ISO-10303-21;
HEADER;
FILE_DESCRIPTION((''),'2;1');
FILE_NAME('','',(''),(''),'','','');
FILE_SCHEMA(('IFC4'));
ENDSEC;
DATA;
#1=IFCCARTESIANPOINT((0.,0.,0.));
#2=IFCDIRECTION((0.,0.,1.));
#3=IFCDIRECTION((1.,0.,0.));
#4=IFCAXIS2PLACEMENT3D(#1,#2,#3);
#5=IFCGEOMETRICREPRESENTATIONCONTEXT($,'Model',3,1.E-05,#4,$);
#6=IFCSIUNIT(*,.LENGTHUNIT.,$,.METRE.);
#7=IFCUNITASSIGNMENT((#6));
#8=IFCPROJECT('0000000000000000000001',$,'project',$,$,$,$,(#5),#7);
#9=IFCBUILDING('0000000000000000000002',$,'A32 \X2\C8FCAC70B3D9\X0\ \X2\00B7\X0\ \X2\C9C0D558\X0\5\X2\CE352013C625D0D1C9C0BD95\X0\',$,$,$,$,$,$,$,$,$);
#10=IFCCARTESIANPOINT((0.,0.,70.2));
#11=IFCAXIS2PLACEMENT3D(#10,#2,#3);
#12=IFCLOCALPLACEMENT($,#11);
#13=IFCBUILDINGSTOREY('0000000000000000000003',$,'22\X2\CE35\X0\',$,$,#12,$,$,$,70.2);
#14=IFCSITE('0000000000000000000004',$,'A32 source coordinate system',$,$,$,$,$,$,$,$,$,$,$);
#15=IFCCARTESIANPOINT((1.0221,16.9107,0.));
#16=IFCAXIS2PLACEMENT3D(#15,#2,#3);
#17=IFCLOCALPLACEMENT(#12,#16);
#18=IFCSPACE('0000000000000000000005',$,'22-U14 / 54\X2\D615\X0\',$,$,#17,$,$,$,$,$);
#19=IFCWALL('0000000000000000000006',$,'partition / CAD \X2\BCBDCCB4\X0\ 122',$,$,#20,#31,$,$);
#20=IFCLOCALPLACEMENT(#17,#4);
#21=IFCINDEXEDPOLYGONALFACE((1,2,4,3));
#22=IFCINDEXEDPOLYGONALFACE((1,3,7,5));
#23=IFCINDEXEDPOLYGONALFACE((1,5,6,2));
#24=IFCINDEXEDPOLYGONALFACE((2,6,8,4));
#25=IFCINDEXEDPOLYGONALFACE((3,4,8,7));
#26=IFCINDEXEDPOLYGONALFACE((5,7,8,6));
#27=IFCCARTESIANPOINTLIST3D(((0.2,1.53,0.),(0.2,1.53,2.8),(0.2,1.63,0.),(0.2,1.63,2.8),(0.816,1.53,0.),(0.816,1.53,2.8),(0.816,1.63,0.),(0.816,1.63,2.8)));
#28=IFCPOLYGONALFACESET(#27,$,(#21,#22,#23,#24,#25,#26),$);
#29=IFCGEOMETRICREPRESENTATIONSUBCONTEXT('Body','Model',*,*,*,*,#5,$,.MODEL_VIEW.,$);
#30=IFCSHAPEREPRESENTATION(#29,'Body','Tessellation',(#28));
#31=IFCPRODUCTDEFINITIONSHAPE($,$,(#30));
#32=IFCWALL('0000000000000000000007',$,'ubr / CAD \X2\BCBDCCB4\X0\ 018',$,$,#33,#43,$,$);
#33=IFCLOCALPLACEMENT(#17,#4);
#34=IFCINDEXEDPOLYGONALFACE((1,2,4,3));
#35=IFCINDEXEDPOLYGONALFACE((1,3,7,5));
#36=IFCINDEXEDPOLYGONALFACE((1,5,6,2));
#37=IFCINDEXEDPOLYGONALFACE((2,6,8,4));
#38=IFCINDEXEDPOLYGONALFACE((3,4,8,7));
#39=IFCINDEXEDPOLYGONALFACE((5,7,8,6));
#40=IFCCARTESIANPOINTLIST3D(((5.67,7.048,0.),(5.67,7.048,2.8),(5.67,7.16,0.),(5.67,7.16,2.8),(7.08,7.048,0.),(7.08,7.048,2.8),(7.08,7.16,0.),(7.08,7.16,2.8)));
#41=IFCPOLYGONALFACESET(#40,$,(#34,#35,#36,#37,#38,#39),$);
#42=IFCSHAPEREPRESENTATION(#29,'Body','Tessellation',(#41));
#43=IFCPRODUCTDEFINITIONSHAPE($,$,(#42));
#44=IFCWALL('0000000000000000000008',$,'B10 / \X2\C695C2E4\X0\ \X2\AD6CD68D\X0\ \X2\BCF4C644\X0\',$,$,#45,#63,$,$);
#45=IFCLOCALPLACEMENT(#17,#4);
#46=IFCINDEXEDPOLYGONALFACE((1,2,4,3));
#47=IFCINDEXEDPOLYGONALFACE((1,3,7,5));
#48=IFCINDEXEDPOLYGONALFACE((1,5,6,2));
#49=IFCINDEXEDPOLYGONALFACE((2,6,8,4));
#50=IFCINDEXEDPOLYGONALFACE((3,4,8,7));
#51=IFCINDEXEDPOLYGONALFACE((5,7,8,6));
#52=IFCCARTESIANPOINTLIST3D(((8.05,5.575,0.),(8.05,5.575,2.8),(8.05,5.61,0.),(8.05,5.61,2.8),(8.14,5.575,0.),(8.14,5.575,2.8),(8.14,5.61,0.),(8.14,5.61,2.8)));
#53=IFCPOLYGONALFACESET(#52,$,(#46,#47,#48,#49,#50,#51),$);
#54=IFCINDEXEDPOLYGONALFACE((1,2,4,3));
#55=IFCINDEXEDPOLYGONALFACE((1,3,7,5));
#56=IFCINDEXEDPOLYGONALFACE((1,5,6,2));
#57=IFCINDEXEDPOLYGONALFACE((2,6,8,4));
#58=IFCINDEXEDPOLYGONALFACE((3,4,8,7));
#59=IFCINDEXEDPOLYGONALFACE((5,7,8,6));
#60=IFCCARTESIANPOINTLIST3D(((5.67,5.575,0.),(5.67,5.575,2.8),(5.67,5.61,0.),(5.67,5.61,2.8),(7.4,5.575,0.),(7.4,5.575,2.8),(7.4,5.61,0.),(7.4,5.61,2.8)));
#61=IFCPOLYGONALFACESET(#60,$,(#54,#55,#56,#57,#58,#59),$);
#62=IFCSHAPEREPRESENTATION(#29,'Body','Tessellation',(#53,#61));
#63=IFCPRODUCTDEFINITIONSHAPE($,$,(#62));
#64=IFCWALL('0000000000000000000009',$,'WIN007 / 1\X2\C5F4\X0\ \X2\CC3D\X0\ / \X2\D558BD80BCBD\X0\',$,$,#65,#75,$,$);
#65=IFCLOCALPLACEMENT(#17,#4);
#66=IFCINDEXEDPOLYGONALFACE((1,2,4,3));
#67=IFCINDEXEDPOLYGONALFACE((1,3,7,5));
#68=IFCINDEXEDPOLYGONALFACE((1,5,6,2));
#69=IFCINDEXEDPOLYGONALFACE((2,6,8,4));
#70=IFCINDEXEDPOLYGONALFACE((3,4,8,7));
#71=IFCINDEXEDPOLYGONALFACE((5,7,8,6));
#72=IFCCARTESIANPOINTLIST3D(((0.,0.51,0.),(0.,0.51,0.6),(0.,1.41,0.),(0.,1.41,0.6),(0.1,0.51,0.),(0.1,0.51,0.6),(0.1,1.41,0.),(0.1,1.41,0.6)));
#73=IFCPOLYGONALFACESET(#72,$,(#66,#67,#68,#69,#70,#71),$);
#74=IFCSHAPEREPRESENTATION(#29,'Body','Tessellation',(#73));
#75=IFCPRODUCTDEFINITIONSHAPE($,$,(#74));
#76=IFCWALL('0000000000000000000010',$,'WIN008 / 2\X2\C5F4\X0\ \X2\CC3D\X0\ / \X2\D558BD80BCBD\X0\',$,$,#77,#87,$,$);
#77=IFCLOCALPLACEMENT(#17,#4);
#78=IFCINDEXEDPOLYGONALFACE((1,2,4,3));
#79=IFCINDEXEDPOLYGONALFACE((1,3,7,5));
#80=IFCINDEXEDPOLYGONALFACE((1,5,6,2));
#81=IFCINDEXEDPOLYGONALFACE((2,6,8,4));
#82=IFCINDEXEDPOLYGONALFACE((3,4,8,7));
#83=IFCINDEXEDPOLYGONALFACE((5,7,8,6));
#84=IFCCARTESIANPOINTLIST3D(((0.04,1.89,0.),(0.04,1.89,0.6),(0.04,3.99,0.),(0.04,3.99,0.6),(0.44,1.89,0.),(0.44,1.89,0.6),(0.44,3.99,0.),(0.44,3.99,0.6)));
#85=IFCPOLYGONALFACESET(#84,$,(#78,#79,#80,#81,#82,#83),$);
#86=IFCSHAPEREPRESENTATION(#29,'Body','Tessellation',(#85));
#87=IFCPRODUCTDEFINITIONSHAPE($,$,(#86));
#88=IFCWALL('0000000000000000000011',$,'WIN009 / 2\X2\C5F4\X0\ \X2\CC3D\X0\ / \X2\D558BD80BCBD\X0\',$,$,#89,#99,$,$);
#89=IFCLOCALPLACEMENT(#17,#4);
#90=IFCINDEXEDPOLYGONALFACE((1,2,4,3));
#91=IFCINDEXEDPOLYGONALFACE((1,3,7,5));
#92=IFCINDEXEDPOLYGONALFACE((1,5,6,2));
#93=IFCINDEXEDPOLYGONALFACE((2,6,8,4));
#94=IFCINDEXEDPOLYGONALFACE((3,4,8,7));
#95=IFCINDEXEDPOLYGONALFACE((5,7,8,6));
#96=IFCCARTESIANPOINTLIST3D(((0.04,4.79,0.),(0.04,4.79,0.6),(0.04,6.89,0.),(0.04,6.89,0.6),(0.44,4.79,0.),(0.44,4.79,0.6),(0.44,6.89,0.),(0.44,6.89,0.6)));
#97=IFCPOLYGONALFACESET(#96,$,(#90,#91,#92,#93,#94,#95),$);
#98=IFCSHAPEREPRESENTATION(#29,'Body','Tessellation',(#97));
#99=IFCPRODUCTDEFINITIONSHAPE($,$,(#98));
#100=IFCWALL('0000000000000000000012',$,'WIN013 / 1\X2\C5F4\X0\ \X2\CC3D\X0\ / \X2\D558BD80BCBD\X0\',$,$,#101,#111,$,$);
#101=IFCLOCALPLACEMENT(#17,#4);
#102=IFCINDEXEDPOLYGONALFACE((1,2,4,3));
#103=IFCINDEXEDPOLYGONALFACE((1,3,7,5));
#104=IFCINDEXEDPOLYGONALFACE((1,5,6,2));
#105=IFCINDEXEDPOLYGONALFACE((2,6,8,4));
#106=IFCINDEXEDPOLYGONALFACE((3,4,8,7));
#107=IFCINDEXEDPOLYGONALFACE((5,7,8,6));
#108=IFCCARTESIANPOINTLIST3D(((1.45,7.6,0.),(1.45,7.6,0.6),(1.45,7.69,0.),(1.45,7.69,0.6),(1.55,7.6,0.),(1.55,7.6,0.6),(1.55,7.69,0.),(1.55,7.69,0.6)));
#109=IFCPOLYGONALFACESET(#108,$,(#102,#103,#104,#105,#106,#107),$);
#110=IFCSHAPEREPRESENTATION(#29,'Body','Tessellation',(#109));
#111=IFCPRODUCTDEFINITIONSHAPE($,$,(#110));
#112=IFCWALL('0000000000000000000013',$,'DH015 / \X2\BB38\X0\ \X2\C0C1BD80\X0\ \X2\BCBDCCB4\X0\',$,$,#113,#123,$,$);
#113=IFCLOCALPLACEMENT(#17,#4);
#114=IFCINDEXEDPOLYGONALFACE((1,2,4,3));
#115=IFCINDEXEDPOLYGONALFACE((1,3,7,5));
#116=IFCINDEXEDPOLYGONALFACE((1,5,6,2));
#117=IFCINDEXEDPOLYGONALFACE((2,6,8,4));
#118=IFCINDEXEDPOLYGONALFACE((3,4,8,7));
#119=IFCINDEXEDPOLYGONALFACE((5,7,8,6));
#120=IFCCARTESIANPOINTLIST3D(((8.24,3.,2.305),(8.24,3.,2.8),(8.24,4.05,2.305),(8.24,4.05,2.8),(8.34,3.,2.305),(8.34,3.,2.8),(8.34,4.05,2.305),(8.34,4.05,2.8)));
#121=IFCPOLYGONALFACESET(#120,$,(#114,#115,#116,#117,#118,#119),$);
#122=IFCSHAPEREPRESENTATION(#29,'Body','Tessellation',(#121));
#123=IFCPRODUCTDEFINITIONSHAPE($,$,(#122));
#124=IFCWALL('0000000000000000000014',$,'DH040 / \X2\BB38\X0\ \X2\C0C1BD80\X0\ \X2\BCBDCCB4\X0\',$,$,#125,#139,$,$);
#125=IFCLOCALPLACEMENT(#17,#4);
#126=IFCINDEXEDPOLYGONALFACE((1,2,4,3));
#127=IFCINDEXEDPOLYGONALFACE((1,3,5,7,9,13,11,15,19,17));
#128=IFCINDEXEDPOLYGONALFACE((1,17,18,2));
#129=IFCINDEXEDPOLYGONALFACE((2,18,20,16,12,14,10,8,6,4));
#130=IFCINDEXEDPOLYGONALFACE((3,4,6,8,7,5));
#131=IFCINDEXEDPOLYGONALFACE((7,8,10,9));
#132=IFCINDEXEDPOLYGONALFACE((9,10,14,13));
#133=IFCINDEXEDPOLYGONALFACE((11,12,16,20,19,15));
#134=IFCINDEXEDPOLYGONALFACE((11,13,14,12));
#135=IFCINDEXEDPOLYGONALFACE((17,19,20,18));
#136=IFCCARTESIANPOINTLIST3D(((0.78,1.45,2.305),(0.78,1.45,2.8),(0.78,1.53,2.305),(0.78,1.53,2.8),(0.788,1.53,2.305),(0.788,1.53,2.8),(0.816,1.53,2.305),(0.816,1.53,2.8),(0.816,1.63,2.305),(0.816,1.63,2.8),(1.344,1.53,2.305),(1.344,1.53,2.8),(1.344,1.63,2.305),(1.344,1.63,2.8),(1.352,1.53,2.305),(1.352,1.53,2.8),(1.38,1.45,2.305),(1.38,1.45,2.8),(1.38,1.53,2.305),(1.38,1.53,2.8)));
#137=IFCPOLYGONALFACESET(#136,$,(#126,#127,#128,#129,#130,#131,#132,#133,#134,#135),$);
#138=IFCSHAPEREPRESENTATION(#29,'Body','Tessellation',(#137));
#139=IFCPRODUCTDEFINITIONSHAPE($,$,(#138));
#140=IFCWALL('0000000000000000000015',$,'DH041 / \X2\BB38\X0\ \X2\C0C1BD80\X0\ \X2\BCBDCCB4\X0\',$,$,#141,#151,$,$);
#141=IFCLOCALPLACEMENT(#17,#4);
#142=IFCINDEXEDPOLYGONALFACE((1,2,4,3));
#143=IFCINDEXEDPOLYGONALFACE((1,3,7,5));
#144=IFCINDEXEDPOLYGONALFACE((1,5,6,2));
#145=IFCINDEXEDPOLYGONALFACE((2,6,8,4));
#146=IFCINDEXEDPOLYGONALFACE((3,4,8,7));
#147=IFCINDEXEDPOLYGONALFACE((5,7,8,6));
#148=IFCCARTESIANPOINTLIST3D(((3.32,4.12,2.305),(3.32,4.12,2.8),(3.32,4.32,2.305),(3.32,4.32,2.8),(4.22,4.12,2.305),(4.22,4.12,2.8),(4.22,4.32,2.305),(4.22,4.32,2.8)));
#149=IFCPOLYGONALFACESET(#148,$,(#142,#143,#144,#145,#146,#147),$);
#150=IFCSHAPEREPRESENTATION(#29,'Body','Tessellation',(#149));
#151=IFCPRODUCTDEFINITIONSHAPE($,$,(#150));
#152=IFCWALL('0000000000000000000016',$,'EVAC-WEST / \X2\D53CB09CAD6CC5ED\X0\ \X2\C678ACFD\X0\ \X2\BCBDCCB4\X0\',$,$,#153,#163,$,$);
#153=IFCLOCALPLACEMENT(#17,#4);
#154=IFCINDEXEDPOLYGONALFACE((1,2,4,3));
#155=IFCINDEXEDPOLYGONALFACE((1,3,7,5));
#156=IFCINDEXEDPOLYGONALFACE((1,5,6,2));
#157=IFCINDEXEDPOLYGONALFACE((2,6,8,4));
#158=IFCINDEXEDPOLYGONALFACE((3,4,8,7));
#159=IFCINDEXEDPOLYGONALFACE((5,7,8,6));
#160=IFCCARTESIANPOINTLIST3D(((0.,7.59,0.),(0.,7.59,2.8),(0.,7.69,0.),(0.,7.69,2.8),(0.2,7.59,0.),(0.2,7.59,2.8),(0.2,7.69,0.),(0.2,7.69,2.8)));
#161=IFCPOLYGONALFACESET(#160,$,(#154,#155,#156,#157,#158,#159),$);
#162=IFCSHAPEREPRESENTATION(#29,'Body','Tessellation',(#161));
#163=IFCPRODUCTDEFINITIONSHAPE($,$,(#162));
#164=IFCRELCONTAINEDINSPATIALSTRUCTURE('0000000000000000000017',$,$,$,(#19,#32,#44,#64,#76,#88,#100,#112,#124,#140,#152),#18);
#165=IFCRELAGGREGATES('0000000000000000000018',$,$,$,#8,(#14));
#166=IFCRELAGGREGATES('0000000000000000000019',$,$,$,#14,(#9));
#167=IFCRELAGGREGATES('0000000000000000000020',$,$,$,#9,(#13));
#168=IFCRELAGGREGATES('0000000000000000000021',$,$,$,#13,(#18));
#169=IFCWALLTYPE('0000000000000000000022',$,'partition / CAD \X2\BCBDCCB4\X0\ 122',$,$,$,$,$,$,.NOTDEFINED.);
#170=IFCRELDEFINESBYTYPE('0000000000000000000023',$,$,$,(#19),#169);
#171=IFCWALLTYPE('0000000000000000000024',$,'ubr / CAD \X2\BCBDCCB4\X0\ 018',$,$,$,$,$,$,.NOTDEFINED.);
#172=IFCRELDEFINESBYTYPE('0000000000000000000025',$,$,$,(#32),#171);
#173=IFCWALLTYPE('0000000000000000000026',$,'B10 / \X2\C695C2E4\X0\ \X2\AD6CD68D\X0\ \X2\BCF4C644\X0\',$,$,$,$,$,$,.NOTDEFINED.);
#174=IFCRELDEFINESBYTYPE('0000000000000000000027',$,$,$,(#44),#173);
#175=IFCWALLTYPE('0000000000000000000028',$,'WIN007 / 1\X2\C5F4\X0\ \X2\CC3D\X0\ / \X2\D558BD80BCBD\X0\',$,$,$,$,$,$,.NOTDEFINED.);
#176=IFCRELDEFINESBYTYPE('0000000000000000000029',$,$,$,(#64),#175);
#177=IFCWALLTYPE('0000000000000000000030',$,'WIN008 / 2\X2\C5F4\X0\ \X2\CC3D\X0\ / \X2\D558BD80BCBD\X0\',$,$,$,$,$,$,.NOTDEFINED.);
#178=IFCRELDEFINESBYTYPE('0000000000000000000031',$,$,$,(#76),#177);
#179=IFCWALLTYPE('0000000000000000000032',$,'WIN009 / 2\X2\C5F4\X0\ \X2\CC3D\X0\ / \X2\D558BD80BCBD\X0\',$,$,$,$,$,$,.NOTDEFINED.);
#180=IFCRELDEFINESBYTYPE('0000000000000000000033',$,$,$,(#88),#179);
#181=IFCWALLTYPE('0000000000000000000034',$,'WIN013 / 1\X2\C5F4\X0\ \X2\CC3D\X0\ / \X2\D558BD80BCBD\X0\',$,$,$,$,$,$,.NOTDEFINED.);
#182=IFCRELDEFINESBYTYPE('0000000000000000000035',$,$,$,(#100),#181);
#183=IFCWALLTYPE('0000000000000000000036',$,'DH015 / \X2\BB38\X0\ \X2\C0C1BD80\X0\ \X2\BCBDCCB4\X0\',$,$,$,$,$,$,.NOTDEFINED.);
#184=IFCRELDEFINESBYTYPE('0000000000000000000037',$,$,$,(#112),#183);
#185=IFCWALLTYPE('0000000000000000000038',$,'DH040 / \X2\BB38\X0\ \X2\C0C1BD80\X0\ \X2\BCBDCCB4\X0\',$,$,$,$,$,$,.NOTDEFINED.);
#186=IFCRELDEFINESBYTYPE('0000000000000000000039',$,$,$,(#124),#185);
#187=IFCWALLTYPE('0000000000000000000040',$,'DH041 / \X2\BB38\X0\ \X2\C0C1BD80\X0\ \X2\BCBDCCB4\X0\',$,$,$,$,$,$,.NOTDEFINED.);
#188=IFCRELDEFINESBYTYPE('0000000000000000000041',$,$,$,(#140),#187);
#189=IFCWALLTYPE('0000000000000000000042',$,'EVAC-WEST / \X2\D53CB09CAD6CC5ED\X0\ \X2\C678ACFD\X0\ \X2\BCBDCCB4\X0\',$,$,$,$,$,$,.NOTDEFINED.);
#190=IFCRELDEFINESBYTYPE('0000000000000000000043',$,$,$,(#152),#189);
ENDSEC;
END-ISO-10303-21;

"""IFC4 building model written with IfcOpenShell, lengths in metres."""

from ifc_helpers import new_model, si_unit, frame, origin, origin_with_axes, place, context, subcontext, project, spatial, polyline, outline, extrude, source, transform, mapped, type_object, type_shapes, element, save


model = new_model("IFC4")

# Units and contexts
model_context = context("Model", 3, precision=1e-05, world=origin_with_axes())
body_context = subcontext(model_context, "Body", "Model", "MODEL_VIEW")
ifc_project = project(units=[si_unit("LENGTHUNIT", "METRE")], contexts=[model_context])

# Site, building, storey, space
site = spatial("IfcSite", under=ifc_project, Name="A32 source coordinate system")
building = spatial("IfcBuilding", under=site, Name="A32 주거동 · 지하5층–옥탑지붕")
storey_placement = place(None, frame((0.0, 0.0, 70.2), z_axis=(0.0, 0.0, 1.0), x_axis=(1.0, 0.0, 0.0)))
storey = spatial("IfcBuildingStorey", under=building, at=storey_placement, Name="22층", Elevation=70.2)
space_placement = place(storey_placement, frame((1.0221, 16.9107, 0.0), z_axis=(0.0, 0.0, 1.0), x_axis=(1.0, 0.0, 0.0)))
space = spatial("IfcSpace", under=storey, at=space_placement, Name="22-U14 / 54형")

# Walls
wall_type_1 = type_object("IfcWallType", Name="partition / CAD 벽체 122", PredefinedType="NOTDEFINED")
shared_shape_1 = source(origin(), body_context, "Body", "SweptSolid", [
    extrude(outline(polyline([(0.816, 1.63), (0.816, 1.53), (0.2, 1.53), (0.2, 1.63), (0.816, 1.63)])), origin(), (0.0, 0.0, 1.0), 2.8),
])
type_shapes(wall_type_1, [shared_shape_1])
wall_1_placement = place(space_placement, origin_with_axes())
element("IfcWall", 1, at=wall_1_placement, inside=space, type_object=wall_type_1, Name="partition / CAD 벽체 122", context=body_context, shape_type="MappedRepresentation", body=[
    mapped(shared_shape_1, transform((0.0, 0.0, 0.0), scale=1.0)),
])
wall_type_2 = type_object("IfcWallType", Name="ubr / CAD 벽체 018", PredefinedType="NOTDEFINED")
shared_shape_2 = source(origin(), body_context, "Body", "SweptSolid", [
    extrude(outline(polyline([(5.67, 7.16), (7.08, 7.16), (7.08, 7.048), (5.67, 7.048), (5.67, 7.16)])), origin(), (0.0, 0.0, 1.0), 2.8),
])
type_shapes(wall_type_2, [shared_shape_2])
wall_2_placement = place(space_placement, origin_with_axes())
element("IfcWall", 2, at=wall_2_placement, inside=space, type_object=wall_type_2, Name="ubr / CAD 벽체 018", context=body_context, shape_type="MappedRepresentation", body=[
    mapped(shared_shape_2, transform((0.0, 0.0, 0.0), scale=1.0)),
])
wall_type_3 = type_object("IfcWallType", Name="B10 / 욕실 구획 보완", PredefinedType="NOTDEFINED")
shared_shape_3 = source(origin(), body_context, "Body", "SweptSolid", [
    extrude(outline(polyline([(8.14, 5.575), (8.05, 5.575), (8.05, 5.61), (8.14, 5.61), (8.14, 5.575)])), origin(), (0.0, 0.0, 1.0), 2.8),
    extrude(outline(polyline([(7.4, 5.575), (5.67, 5.575), (5.67, 5.61), (7.4, 5.61), (7.4, 5.575)])), origin(), (0.0, 0.0, 1.0), 2.8),
])
type_shapes(wall_type_3, [shared_shape_3])
wall_3_placement = place(space_placement, origin_with_axes())
element("IfcWall", 3, at=wall_3_placement, inside=space, type_object=wall_type_3, Name="B10 / 욕실 구획 보완", context=body_context, shape_type="MappedRepresentation", body=[
    mapped(shared_shape_3, transform((0.0, 0.0, 0.0), scale=1.0)),
])
wall_type_4 = type_object("IfcWallType", Name="WIN007 / 1열 창 / 하부벽", PredefinedType="NOTDEFINED")
shared_shape_4 = source(origin(), body_context, "Body", "SweptSolid", [
    extrude(outline(polyline([(0.1, 1.41), (0.1, 0.51), (0.0, 0.51), (0.0, 1.41), (0.1, 1.41)])), origin(), (0.0, 0.0, 1.0), 0.6),
])
type_shapes(wall_type_4, [shared_shape_4])
wall_4_placement = place(space_placement, origin_with_axes())
element("IfcWall", 4, at=wall_4_placement, inside=space, type_object=wall_type_4, Name="WIN007 / 1열 창 / 하부벽", context=body_context, shape_type="MappedRepresentation", body=[
    mapped(shared_shape_4, transform((0.0, 0.0, 0.0), scale=1.0)),
])
wall_type_5 = type_object("IfcWallType", Name="WIN008 / 2열 창 / 하부벽", PredefinedType="NOTDEFINED")
shared_shape_5 = source(origin(), body_context, "Body", "SweptSolid", [
    extrude(outline(polyline([(0.44, 3.99), (0.44, 1.89), (0.04, 1.89), (0.04, 3.99), (0.44, 3.99)])), origin(), (0.0, 0.0, 1.0), 0.6),
])
type_shapes(wall_type_5, [shared_shape_5])
wall_5_placement = place(space_placement, origin_with_axes())
element("IfcWall", 5, at=wall_5_placement, inside=space, type_object=wall_type_5, Name="WIN008 / 2열 창 / 하부벽", context=body_context, shape_type="MappedRepresentation", body=[
    mapped(shared_shape_5, transform((0.0, 0.0, 0.0), scale=1.0)),
])
wall_type_6 = type_object("IfcWallType", Name="WIN009 / 2열 창 / 하부벽", PredefinedType="NOTDEFINED")
shared_shape_6 = source(origin(), body_context, "Body", "SweptSolid", [
    extrude(outline(polyline([(0.44, 6.89), (0.44, 4.79), (0.04, 4.79), (0.04, 6.89), (0.44, 6.89)])), origin(), (0.0, 0.0, 1.0), 0.6),
])
type_shapes(wall_type_6, [shared_shape_6])
wall_6_placement = place(space_placement, origin_with_axes())
element("IfcWall", 6, at=wall_6_placement, inside=space, type_object=wall_type_6, Name="WIN009 / 2열 창 / 하부벽", context=body_context, shape_type="MappedRepresentation", body=[
    mapped(shared_shape_6, transform((0.0, 0.0, 0.0), scale=1.0)),
])
wall_type_7 = type_object("IfcWallType", Name="WIN013 / 1열 창 / 하부벽", PredefinedType="NOTDEFINED")
shared_shape_7 = source(origin(), body_context, "Body", "SweptSolid", [
    extrude(outline(polyline([(1.55, 7.6), (1.45, 7.6), (1.45, 7.69), (1.55, 7.69), (1.55, 7.6)])), origin(), (0.0, 0.0, 1.0), 0.6),
])
type_shapes(wall_type_7, [shared_shape_7])
wall_7_placement = place(space_placement, origin_with_axes())
element("IfcWall", 7, at=wall_7_placement, inside=space, type_object=wall_type_7, Name="WIN013 / 1열 창 / 하부벽", context=body_context, shape_type="MappedRepresentation", body=[
    mapped(shared_shape_7, transform((0.0, 0.0, 0.0), scale=1.0)),
])
wall_type_8 = type_object("IfcWallType", Name="DH015 / 문 상부 벽체", PredefinedType="NOTDEFINED")
shared_shape_8 = source(origin(), body_context, "Body", "SweptSolid", [
    extrude(outline(polyline([(8.34, 3.0), (8.24, 3.0), (8.24, 4.05), (8.34, 4.05), (8.34, 3.0)])), frame((0.0, 0.0, 2.305)), (0.0, 0.0, 1.0), 0.495),
])
type_shapes(wall_type_8, [shared_shape_8])
wall_8_placement = place(space_placement, origin_with_axes())
element("IfcWall", 8, at=wall_8_placement, inside=space, type_object=wall_type_8, Name="DH015 / 문 상부 벽체", context=body_context, shape_type="MappedRepresentation", body=[
    mapped(shared_shape_8, transform((0.0, 0.0, 0.0), scale=1.0)),
])
wall_type_9 = type_object("IfcWallType", Name="DH040 / 문 상부 벽체", PredefinedType="NOTDEFINED")
shared_shape_9 = source(origin(), body_context, "Body", "SweptSolid", [
    extrude(outline(polyline([(0.816, 1.63), (1.344, 1.63), (1.344, 1.53), (1.352, 1.53), (1.38, 1.53), (1.38, 1.45), (0.78, 1.45), (0.78, 1.53), (0.788, 1.53), (0.816, 1.53), (0.816, 1.63)])), frame((0.0, 0.0, 2.305)), (0.0, 0.0, 1.0), 0.495),
])
type_shapes(wall_type_9, [shared_shape_9])
wall_9_placement = place(space_placement, origin_with_axes())
element("IfcWall", 9, at=wall_9_placement, inside=space, type_object=wall_type_9, Name="DH040 / 문 상부 벽체", context=body_context, shape_type="MappedRepresentation", body=[
    mapped(shared_shape_9, transform((0.0, 0.0, 0.0), scale=1.0)),
])
wall_type_10 = type_object("IfcWallType", Name="DH041 / 문 상부 벽체", PredefinedType="NOTDEFINED")
shared_shape_10 = source(origin(), body_context, "Body", "SweptSolid", [
    extrude(outline(polyline([(4.22, 4.12), (3.32, 4.12), (3.32, 4.32), (4.22, 4.32), (4.22, 4.12)])), frame((0.0, 0.0, 2.305)), (0.0, 0.0, 1.0), 0.495),
])
type_shapes(wall_type_10, [shared_shape_10])
wall_10_placement = place(space_placement, origin_with_axes())
element("IfcWall", 10, at=wall_10_placement, inside=space, type_object=wall_type_10, Name="DH041 / 문 상부 벽체", context=body_context, shape_type="MappedRepresentation", body=[
    mapped(shared_shape_10, transform((0.0, 0.0, 0.0), scale=1.0)),
])
wall_type_11 = type_object("IfcWallType", Name="EVAC-WEST / 피난구역 외곽 벽체", PredefinedType="NOTDEFINED")
shared_shape_11 = source(origin(), body_context, "Body", "SweptSolid", [
    extrude(outline(polyline([(0.2, 7.59), (0.0, 7.59), (0.0, 7.69), (0.2, 7.69), (0.2, 7.59)])), origin(), (0.0, 0.0, 1.0), 2.8),
])
type_shapes(wall_type_11, [shared_shape_11])
wall_11_placement = place(space_placement, origin_with_axes())
element("IfcWall", 11, at=wall_11_placement, inside=space, type_object=wall_type_11, Name="EVAC-WEST / 피난구역 외곽 벽체", context=body_context, shape_type="MappedRepresentation", body=[
    mapped(shared_shape_11, transform((0.0, 0.0, 0.0), scale=1.0)),
])

save(model, "model.ifc")
